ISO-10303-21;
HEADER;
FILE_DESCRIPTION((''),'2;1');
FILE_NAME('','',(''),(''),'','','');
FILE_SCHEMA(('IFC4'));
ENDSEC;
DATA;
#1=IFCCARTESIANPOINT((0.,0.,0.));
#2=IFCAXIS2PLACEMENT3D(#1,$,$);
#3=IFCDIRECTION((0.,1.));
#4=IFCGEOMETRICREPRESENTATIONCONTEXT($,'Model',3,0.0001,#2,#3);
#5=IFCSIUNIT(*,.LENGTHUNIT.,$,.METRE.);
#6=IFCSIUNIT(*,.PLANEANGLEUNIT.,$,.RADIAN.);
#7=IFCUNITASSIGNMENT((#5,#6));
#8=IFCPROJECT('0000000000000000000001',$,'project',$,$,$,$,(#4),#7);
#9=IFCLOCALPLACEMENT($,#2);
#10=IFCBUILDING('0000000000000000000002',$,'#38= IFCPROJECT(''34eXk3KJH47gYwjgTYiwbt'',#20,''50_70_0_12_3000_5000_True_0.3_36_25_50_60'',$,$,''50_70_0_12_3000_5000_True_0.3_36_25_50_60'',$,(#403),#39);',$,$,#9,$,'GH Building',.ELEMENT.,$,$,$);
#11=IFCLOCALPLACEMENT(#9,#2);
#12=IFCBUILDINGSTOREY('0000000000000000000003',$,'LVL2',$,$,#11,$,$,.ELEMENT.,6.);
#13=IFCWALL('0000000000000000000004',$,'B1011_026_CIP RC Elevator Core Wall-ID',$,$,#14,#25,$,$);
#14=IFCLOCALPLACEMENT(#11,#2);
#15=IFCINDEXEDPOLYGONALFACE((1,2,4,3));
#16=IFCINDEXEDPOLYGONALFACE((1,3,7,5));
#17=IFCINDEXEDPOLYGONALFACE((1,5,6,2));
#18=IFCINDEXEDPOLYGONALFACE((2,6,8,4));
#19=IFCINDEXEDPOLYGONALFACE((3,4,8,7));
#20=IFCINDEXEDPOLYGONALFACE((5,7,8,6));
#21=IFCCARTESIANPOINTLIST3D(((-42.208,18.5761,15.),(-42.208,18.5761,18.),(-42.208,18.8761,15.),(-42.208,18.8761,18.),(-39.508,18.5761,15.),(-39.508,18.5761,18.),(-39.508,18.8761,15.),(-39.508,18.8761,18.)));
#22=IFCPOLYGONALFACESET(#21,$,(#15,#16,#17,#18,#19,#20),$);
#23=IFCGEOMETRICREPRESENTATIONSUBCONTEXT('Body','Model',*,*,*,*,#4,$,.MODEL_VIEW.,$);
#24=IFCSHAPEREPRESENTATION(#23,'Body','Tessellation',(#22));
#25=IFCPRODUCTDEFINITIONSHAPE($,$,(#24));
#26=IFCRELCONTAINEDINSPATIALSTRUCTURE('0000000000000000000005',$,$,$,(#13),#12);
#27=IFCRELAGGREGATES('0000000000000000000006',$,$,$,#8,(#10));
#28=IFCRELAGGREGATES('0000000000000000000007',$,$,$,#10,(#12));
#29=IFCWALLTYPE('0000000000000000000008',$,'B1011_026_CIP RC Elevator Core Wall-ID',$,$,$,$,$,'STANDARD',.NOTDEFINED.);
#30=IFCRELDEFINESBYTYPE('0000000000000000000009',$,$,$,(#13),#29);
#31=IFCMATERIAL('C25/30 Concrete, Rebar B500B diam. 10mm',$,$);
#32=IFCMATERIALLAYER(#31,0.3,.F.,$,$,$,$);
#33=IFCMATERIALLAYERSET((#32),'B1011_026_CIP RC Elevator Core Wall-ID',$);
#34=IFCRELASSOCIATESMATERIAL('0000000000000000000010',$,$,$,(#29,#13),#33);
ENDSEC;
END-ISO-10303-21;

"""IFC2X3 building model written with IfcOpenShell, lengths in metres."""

from ifc_helpers import new_model, si_unit, direction, frame, frame_2d, origin, place, context, subcontext, project, spatial, rectangle, extrude, material, layer, layer_set, layer_usage, type_object, element, save


model = new_model("IFC2X3")

# Units and contexts
model_context = context("Model", 3, precision=0.0001, world=origin(), true_north=direction((0.0, 1.0)))
body_context = subcontext(model_context, "Body", "Model", "MODEL_VIEW")
ifc_project = project(units=[si_unit("LENGTHUNIT", "METRE"), si_unit("PLANEANGLEUNIT", "RADIAN")], contexts=[model_context])

# Building, storey
building_placement = place(None, origin())
building = spatial("IfcBuilding", under=ifc_project, at=building_placement, Name="#38= IFCPROJECT('34eXk3KJH47gYwjgTYiwbt',#20,'50_70_0_12_3000_5000_True_0.3_36_25_50_60',$,$,'50_70_0_12_3000_5000_True_0.3_36_25_50_60',$,(#403),#39);", LongName="GH Building", CompositionType="ELEMENT")
storey_placement = place(building_placement, origin())
storey = spatial("IfcBuildingStorey", under=building, at=storey_placement, Name="LVL2", CompositionType="ELEMENT", Elevation=6.0)

# Wall
ifc_material_1 = material(Name="C25/30 Concrete, Rebar B500B diam. 10mm")
ifc_layer_1 = layer(ifc_material_1, 0.3, ventilated=False)
ifc_layer_set_1 = layer_set([ifc_layer_1], Name="B1011_026_CIP RC Elevator Core Wall-ID")
wall_type_1 = type_object("IfcWallType", Name="B1011_026_CIP RC Elevator Core Wall-ID", ElementType="STANDARD", PredefinedType="NOTDEFINED", material=ifc_layer_set_1)
ifc_layer_usage_1 = layer_usage(ifc_layer_set_1, "AXIS2", "POSITIVE", 0.0)
wall_1_placement = place(storey_placement, frame((-39.508, 18.8761, 15.0), z_axis=(0.0, 0.0, 1.0), x_axis=(-1.0, 0.0, 0.0)))
element("IfcWall", 1, at=wall_1_placement, inside=storey, type_object=wall_type_1, material=ifc_layer_usage_1, Name="B1011_026_CIP RC Elevator Core Wall-ID", context=body_context, shape_type="SweptSolid", body=[
    extrude(rectangle(XDim=2.7, YDim=0.3, at=frame_2d((1.35, 0.15))), origin(), (0.0, 0.0, 1.0), 3.0),
])

save(model, "model.ifc")
